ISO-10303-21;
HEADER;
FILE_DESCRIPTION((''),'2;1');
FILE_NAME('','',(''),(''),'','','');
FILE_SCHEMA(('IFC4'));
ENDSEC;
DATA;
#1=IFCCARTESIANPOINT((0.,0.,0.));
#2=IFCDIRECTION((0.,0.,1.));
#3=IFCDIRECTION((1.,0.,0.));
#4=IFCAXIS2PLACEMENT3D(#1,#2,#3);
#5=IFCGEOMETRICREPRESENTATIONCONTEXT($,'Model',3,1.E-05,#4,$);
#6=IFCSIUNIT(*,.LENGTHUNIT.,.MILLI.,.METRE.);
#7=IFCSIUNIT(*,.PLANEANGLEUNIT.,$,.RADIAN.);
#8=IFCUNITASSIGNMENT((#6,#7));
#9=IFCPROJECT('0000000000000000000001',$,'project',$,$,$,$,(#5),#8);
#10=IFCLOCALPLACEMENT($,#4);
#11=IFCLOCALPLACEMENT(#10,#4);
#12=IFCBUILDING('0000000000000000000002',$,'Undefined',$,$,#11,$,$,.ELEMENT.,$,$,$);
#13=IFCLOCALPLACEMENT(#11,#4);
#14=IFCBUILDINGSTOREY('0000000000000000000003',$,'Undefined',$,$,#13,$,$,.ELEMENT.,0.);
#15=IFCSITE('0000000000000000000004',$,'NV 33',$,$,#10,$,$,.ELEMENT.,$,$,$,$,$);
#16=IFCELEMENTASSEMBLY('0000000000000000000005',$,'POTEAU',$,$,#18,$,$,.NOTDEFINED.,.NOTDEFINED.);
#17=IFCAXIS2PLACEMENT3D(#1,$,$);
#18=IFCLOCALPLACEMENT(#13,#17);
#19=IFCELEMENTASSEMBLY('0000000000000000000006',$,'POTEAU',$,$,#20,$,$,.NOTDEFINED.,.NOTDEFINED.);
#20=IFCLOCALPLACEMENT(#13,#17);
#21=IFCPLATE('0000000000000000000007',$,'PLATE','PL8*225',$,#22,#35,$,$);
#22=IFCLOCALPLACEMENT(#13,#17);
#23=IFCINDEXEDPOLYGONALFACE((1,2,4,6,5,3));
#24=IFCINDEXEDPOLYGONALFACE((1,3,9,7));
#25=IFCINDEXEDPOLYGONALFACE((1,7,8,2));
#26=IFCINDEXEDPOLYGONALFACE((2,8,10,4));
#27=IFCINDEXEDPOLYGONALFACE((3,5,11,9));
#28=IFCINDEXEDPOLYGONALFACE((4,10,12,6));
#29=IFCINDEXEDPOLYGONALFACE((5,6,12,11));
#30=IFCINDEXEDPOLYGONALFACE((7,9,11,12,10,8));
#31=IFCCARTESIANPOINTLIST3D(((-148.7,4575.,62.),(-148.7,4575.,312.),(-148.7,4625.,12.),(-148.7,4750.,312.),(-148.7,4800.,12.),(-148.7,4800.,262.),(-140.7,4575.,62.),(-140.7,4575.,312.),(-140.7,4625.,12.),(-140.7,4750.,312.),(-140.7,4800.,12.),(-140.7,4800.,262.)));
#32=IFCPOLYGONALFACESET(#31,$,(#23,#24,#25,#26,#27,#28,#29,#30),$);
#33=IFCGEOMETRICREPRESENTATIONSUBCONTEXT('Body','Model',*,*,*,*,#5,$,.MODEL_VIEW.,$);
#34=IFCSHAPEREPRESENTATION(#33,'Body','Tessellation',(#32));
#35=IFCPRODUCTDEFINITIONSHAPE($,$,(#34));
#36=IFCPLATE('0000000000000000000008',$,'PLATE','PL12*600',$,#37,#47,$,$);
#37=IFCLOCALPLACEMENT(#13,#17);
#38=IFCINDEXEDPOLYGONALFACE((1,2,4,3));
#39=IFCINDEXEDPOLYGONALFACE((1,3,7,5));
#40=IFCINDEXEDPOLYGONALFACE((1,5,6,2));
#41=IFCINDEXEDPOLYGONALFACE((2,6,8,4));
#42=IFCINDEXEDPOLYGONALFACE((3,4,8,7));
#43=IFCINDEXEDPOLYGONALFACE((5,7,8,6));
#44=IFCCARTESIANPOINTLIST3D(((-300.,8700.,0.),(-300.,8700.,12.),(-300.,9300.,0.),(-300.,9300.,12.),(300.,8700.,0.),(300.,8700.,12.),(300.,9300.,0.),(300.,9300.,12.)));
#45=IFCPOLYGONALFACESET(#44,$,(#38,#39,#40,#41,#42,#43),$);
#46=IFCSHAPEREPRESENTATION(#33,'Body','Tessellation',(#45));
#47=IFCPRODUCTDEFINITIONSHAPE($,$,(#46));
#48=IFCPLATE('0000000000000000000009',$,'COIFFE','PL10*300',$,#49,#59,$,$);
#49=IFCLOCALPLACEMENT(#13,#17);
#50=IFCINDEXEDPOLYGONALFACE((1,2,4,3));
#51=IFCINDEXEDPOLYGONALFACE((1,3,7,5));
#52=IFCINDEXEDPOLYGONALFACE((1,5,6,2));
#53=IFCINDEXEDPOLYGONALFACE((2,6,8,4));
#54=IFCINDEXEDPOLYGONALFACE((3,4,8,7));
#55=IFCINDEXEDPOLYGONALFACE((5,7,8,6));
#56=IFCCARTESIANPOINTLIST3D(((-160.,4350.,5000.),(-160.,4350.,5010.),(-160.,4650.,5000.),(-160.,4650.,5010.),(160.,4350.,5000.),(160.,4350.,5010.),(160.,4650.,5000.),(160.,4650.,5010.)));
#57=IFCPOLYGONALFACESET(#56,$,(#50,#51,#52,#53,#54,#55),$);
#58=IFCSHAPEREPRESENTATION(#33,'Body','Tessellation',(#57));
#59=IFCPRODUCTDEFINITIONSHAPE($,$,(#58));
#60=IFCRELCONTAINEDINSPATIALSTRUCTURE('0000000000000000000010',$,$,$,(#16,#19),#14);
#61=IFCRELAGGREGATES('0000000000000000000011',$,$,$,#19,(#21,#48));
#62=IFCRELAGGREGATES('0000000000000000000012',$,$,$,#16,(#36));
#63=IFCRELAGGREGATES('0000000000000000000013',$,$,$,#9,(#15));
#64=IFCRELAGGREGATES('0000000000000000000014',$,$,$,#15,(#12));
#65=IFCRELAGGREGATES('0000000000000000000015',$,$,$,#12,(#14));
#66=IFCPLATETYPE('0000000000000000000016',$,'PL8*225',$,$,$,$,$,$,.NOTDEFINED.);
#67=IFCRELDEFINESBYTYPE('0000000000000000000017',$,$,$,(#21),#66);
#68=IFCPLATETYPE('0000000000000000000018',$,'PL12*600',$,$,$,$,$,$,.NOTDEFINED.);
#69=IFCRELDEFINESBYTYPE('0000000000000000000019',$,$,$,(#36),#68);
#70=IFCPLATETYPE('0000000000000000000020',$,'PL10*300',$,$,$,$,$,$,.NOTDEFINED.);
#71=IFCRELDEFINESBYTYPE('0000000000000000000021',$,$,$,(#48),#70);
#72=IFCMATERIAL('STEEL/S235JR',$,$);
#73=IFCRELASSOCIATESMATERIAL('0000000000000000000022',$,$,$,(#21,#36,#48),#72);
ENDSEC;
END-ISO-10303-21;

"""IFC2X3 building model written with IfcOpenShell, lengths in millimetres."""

from ifc_helpers import new_model, si_unit, frame, origin_with_axes, place, context, subcontext, project, spatial, polyline, outline, extrude, material, type_object, element, aggregate, save


model = new_model("IFC2X3")

# Units and contexts
model_context = context("Model", 3, precision=1e-05, world=origin_with_axes())
body_context = subcontext(model_context, "Body", "Model", "MODEL_VIEW")
ifc_project = project(units=[si_unit("LENGTHUNIT", "METRE", prefix="MILLI"), si_unit("PLANEANGLEUNIT", "RADIAN")], contexts=[model_context])

# Site, building, storey
site_placement = place(None, origin_with_axes())
site = spatial("IfcSite", under=ifc_project, at=site_placement, Name="NV 33", CompositionType="ELEMENT")
building_placement = place(site_placement, origin_with_axes())
building = spatial("IfcBuilding", under=site, at=building_placement, Name="Undefined", CompositionType="ELEMENT")
storey_placement = place(building_placement, origin_with_axes())
storey = spatial("IfcBuildingStorey", under=building, at=storey_placement, Name="Undefined", CompositionType="ELEMENT", Elevation=0.0)

# Element assembly
assembly_1_placement = place(storey_placement, origin_with_axes())
assembly_1 = element("IfcElementAssembly", 1, at=assembly_1_placement, inside=storey, Name="POTEAU", AssemblyPlace="NOTDEFINED", PredefinedType="NOTDEFINED")
ifc_material_1 = material(Name="STEEL/S235JR")

# Element assembly
assembly_2_placement = place(storey_placement, origin_with_axes())
assembly_2 = element("IfcElementAssembly", 2, at=assembly_2_placement, inside=storey, Name="POTEAU", AssemblyPlace="NOTDEFINED", PredefinedType="NOTDEFINED")

# Plates
plate_type_1 = type_object("IfcPlateType", Name="PL8*225", PredefinedType="NOTDEFINED")
plate_1_placement = place(assembly_2_placement, frame((-144.7, 4575.0, 12.0), z_axis=(1.0, 0.0, 0.0), x_axis=(0.0, 1.0, 0.0)))
plate_1 = element("IfcPlate", 3, at=plate_1_placement, type_object=plate_type_1, material=ifc_material_1, Name="PLATE", Description="PL8*225", context=body_context, shape_type="SweptSolid", body=[
    extrude(outline(polyline([(0.0, 50.0), (50.0, 0.0), (225.0, 0.0), (225.0, 250.0), (175.0, 300.0), (0.0, 300.0), (0.0, 50.0)])), frame((0.0, 0.0, -4.0), z_axis=(0.0, 0.0, 1.0), x_axis=(1.0, 0.0, 0.0)), (0.0, 0.0, 1.0), 8.0),
])
plate_type_2 = type_object("IfcPlateType", Name="PL12*600", PredefinedType="NOTDEFINED")
plate_2_placement = place(assembly_1_placement, frame((-300.0, 8700.0, 6.0), z_axis=(0.0, 0.0, 1.0), x_axis=(1.0, 0.0, 0.0)))
plate_2 = element("IfcPlate", 4, at=plate_2_placement, type_object=plate_type_2, material=ifc_material_1, Name="PLATE", Description="PL12*600", context=body_context, shape_type="SweptSolid", body=[
    extrude(outline(polyline([(0.0, 0.0), (600.0, 0.0), (600.0, 600.0), (0.0, 600.0), (0.0, 0.0)])), frame((0.0, 0.0, -6.0), z_axis=(0.0, 0.0, 1.0), x_axis=(1.0, 0.0, 0.0)), (0.0, 0.0, 1.0), 12.0),
])
plate_type_3 = type_object("IfcPlateType", Name="PL10*300", PredefinedType="NOTDEFINED")
plate_3_placement = place(assembly_2_placement, frame((-160.0, 4650.0, 5005.0), z_axis=(0.0, 0.0, 1.0), x_axis=(0.0, -1.0, 0.0)))
plate_3 = element("IfcPlate", 5, at=plate_3_placement, type_object=plate_type_3, material=ifc_material_1, Name="COIFFE", Description="PL10*300", context=body_context, shape_type="SweptSolid", body=[
    extrude(outline(polyline([(0.0, 0.0), (300.0, 0.0), (300.0, 320.0), (0.0, 320.0), (0.0, 0.0)])), frame((0.0, 0.0, -5.0), z_axis=(0.0, 0.0, 1.0), x_axis=(1.0, 0.0, 0.0)), (0.0, 0.0, 1.0), 10.0),
])
aggregate(assembly_2, [plate_1, plate_3])

aggregate(assembly_1, [plate_2])

save(model, "model.ifc")
